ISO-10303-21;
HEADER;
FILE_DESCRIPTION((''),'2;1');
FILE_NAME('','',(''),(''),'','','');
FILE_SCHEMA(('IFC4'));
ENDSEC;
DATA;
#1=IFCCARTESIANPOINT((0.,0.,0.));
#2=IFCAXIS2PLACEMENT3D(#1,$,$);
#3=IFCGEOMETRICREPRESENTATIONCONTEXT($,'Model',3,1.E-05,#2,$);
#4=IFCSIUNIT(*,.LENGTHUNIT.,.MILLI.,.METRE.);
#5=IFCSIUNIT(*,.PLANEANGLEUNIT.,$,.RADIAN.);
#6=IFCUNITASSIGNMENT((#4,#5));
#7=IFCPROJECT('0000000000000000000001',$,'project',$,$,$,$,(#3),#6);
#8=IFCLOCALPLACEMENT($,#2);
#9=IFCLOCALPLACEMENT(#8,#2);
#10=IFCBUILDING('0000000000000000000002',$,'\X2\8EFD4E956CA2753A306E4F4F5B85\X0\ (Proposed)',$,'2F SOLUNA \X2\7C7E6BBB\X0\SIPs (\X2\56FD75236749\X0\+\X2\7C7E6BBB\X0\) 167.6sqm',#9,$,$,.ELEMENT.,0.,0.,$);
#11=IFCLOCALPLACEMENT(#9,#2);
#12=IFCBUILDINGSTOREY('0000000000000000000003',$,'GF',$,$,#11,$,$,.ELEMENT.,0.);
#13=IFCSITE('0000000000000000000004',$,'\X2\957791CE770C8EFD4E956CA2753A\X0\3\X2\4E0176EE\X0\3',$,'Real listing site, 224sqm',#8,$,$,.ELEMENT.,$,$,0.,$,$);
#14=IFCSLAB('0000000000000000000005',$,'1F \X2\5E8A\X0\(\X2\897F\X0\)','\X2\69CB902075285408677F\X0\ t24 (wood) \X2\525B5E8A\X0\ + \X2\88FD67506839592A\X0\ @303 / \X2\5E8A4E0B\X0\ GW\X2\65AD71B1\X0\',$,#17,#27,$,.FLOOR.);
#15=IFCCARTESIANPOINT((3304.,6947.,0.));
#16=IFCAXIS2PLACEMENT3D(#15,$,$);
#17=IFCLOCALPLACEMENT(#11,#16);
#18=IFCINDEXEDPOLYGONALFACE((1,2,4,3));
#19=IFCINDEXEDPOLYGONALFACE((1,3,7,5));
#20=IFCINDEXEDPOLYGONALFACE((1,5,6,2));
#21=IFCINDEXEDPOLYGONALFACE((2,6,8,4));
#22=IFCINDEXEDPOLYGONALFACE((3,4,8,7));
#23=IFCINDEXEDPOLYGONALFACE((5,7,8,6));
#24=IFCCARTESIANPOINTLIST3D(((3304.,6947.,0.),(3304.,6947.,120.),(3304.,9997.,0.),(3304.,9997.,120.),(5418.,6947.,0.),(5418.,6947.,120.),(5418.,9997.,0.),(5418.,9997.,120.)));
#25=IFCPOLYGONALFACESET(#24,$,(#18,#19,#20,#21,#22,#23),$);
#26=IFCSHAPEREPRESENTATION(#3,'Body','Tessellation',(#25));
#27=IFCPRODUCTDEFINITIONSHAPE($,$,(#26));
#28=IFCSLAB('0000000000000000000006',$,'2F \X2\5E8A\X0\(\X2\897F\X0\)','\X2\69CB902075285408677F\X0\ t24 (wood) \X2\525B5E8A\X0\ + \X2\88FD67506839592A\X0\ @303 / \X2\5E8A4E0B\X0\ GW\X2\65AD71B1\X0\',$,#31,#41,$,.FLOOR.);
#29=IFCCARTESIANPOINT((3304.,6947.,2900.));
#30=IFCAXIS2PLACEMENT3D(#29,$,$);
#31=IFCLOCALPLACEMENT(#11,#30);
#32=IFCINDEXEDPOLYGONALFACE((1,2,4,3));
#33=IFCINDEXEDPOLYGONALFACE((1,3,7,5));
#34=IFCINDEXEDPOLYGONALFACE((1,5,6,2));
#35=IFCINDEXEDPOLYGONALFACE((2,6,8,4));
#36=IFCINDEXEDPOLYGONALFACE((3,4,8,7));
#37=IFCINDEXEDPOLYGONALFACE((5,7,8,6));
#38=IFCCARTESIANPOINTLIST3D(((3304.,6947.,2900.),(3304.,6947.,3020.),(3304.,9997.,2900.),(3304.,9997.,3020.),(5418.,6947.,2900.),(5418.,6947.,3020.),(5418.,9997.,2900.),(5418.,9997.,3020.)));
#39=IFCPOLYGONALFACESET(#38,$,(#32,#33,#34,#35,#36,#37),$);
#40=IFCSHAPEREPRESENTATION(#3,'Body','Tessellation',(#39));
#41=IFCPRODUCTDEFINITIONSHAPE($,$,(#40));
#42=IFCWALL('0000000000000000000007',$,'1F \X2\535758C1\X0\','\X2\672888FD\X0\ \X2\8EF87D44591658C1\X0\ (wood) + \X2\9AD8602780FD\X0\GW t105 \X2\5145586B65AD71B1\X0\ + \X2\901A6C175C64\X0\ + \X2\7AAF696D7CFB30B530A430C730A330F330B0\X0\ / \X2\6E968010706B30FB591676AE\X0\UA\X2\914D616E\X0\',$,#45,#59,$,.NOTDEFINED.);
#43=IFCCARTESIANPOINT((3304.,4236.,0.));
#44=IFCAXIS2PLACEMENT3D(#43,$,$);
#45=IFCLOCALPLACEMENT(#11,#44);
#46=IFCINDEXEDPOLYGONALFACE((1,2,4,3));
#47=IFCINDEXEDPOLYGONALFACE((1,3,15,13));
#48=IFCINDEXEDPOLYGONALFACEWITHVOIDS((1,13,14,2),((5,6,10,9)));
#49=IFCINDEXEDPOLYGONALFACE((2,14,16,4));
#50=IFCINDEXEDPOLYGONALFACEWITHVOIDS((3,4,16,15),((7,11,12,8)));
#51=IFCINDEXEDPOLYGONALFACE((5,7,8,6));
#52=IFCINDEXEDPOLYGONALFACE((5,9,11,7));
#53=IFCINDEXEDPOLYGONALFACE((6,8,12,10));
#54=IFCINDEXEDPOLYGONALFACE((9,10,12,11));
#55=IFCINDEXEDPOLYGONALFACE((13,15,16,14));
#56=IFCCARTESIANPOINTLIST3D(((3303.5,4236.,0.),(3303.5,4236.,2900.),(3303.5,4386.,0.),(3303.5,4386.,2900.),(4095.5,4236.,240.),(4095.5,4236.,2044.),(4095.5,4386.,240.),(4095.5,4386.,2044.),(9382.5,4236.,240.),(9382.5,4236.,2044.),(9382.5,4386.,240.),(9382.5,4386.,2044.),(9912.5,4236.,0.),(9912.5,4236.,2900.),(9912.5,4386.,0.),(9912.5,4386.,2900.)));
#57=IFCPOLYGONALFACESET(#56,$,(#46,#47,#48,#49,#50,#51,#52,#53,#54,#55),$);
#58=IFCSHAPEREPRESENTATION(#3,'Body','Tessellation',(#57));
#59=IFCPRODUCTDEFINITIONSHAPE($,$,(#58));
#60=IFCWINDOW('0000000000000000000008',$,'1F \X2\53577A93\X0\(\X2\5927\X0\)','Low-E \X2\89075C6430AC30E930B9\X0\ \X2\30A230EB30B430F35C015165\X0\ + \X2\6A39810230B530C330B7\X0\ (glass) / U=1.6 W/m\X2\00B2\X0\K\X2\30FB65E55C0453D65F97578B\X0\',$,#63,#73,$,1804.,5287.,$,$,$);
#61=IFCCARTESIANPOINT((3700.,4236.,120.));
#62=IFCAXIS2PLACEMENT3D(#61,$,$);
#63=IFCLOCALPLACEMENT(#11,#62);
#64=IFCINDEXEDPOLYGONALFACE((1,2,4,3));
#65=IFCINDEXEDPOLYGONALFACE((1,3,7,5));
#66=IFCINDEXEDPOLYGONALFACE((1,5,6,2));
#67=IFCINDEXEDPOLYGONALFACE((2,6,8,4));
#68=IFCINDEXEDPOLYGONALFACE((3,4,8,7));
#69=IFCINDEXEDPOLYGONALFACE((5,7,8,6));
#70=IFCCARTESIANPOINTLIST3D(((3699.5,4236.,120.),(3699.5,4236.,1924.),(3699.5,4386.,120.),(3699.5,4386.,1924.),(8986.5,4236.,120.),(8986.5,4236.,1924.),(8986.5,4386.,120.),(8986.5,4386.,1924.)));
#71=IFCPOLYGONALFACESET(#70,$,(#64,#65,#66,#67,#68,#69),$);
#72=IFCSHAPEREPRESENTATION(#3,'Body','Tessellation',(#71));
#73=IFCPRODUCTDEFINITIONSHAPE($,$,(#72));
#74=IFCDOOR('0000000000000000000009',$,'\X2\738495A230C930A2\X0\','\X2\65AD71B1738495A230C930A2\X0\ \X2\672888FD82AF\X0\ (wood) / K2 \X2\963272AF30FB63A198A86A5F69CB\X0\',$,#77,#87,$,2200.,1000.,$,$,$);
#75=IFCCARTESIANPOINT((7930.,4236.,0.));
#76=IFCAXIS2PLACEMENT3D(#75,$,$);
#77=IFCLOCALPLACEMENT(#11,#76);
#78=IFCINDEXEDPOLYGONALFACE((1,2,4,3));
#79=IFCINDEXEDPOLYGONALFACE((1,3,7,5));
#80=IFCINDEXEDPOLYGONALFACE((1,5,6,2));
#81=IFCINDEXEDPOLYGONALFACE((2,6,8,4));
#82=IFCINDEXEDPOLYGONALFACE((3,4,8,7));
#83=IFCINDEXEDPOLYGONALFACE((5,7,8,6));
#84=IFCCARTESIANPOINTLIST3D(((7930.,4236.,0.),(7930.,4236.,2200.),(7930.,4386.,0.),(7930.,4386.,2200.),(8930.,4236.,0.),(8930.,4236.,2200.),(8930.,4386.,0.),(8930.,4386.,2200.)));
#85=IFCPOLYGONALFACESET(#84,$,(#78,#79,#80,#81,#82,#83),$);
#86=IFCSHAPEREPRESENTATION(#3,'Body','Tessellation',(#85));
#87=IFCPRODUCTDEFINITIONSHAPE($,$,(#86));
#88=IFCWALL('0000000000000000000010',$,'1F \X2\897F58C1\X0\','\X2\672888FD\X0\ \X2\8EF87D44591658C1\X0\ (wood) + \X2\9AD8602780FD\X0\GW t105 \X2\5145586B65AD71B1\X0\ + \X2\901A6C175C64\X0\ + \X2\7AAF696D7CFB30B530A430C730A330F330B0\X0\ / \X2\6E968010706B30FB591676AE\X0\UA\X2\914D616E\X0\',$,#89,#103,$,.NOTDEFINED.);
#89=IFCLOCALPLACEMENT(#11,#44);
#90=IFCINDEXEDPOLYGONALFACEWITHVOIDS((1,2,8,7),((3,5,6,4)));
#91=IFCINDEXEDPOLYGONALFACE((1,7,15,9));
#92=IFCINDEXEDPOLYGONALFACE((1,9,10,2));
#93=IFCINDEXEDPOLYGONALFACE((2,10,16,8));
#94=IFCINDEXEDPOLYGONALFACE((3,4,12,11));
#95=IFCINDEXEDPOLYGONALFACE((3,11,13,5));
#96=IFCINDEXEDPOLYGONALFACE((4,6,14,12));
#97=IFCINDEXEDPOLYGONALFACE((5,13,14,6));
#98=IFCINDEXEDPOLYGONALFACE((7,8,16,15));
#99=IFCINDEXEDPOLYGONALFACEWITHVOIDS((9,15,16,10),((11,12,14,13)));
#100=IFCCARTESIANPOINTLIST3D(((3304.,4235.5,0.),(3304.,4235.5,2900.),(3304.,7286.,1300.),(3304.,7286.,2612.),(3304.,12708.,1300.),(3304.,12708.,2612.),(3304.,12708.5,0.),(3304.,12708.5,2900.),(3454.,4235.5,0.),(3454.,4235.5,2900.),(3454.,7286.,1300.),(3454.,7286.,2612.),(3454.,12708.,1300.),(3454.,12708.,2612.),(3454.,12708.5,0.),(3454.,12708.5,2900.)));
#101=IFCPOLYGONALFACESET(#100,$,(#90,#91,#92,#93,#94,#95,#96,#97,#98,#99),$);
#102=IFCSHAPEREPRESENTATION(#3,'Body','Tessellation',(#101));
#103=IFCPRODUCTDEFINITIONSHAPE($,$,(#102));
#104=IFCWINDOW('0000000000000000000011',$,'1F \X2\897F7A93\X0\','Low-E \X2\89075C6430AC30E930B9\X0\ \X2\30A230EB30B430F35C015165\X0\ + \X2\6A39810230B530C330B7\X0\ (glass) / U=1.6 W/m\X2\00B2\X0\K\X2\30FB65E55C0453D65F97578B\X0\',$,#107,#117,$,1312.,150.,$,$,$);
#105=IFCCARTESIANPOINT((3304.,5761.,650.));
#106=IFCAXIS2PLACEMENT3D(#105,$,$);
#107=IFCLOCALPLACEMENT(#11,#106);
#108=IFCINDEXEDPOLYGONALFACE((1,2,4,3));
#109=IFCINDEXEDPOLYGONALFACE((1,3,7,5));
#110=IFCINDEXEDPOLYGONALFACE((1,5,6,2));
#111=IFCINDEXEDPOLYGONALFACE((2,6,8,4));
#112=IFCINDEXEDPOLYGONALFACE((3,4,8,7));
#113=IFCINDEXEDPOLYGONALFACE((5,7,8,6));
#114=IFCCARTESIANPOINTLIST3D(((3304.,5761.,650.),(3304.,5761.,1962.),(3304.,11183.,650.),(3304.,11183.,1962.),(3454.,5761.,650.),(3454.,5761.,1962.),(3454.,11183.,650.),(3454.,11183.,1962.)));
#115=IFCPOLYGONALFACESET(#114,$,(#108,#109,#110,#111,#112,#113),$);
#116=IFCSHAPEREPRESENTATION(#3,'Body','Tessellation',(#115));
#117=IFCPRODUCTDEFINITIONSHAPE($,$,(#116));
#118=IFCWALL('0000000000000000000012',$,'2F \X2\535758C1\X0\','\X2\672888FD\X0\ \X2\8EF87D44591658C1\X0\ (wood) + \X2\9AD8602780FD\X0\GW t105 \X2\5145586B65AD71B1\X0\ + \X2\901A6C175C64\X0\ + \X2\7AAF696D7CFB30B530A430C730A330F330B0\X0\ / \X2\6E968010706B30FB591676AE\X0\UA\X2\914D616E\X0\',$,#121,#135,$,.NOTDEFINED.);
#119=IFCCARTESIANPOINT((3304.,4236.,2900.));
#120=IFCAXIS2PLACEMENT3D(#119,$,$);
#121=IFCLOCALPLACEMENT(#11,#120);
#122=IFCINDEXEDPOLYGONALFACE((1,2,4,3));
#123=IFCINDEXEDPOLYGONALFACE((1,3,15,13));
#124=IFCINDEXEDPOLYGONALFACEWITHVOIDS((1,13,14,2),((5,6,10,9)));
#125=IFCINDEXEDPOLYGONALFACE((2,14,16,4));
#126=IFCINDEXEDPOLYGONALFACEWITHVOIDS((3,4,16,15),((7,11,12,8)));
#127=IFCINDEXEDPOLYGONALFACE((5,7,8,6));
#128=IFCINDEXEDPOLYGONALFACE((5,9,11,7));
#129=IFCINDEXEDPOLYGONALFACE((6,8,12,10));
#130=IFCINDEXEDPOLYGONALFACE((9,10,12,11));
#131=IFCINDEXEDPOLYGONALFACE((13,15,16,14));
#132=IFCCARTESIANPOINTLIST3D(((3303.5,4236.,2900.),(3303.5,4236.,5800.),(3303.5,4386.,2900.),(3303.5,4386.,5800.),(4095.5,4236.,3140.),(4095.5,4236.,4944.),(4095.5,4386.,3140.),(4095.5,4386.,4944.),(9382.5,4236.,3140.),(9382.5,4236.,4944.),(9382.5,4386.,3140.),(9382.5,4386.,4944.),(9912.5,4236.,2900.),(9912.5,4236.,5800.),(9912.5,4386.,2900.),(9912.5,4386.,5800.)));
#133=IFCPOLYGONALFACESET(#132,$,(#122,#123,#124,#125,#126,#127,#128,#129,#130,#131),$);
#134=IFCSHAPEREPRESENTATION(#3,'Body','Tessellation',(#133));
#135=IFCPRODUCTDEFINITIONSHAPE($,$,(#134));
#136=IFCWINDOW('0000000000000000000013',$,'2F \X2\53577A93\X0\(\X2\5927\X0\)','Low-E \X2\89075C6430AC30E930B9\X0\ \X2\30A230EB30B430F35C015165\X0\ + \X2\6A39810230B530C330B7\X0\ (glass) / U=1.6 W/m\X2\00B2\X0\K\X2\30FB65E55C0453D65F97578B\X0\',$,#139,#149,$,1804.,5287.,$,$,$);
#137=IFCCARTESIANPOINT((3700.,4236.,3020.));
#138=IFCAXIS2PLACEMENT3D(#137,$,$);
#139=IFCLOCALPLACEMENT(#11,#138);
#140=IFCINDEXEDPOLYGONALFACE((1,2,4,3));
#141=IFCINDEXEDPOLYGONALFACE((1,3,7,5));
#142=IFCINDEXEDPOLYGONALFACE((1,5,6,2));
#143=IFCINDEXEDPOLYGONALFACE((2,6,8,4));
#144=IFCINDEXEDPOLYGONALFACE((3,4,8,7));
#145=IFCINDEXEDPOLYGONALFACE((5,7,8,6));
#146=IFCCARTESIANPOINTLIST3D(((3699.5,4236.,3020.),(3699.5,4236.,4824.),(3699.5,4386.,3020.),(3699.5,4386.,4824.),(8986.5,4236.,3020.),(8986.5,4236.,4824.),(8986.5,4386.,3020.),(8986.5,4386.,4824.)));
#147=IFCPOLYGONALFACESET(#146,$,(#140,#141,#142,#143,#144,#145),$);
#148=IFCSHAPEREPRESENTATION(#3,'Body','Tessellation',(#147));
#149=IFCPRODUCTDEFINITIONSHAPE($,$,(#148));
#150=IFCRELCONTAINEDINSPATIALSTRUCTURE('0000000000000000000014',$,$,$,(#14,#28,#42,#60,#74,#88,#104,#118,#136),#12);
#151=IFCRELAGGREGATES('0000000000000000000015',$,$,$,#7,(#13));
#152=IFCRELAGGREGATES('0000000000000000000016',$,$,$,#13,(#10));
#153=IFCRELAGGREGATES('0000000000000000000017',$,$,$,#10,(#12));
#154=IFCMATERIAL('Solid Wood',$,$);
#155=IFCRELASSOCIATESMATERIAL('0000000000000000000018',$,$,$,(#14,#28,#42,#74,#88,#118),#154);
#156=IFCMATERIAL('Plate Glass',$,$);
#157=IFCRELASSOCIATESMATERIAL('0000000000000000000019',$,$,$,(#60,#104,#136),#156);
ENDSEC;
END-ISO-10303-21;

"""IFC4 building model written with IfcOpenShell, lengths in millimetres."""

from ifc_helpers import new_model, si_unit, frame, frame_2d, origin, place, context, project, spatial, rectangle, extrude, material, element, fill, save


model = new_model("IFC4")

# Units and contexts
model_context = context("Model", 3, precision=1e-05, world=origin())
ifc_project = project(units=[si_unit("LENGTHUNIT", "METRE", prefix="MILLI"), si_unit("PLANEANGLEUNIT", "RADIAN")], contexts=[model_context])

# Site, building, storey
site_placement = place(None, origin())
site = spatial("IfcSite", under=ifc_project, at=site_placement, Name="長野県軽井沢町3丁目3", ObjectType="Real listing site, 224sqm", CompositionType="ELEMENT", RefElevation=0.0)
building_placement = place(site_placement, origin())
building = spatial("IfcBuilding", under=site, at=building_placement, Name="軽井沢町の住宅 (Proposed)", ObjectType="2F SOLUNA 籾殻SIPs (国産杉+籾殻) 167.6sqm", CompositionType="ELEMENT", ElevationOfRefHeight=0.0, ElevationOfTerrain=0.0)
storey_placement = place(building_placement, origin())
storey = spatial("IfcBuildingStorey", under=building, at=storey_placement, Name="GF", CompositionType="ELEMENT", Elevation=0.0)

# Slabs
ifc_material_1 = material(Name="Solid Wood")
slab_1_placement = place(storey_placement, frame((3304.0, 6947.0, 0.0)))
element("IfcSlab", 1, at=slab_1_placement, inside=storey, material=ifc_material_1, Name="1F 床(西)", Description="構造用合板 t24 (wood) 剛床 + 製材根太 @303 / 床下 GW断熱", PredefinedType="FLOOR", context=model_context, shape_type="SweptSolid", body=[
    extrude(rectangle(XDim=2114.0, YDim=3050.0, at=frame_2d((1057.0, 1525.0))), frame((3304.0, 6947.0, 0.0)), (0.0, 0.0, 1.0), 120.0),
])
slab_2_placement = place(storey_placement, frame((3304.0, 6947.0, 2900.0)))
element("IfcSlab", 2, at=slab_2_placement, inside=storey, material=ifc_material_1, Name="2F 床(西)", Description="構造用合板 t24 (wood) 剛床 + 製材根太 @303 / 床下 GW断熱", PredefinedType="FLOOR", context=model_context, shape_type="SweptSolid", body=[
    extrude(rectangle(XDim=2114.0, YDim=3050.0, at=frame_2d((1057.0, 1525.0))), frame((3304.0, 6947.0, 2900.0)), (0.0, 0.0, 1.0), 120.0),
])

# Wall, openings, window, door
wall_1_placement = place(storey_placement, frame((3304.0, 4236.0, 0.0)))
wall_1 = element("IfcWall", 3, at=wall_1_placement, inside=storey, material=ifc_material_1, Name="1F 南壁", Description="木製 軸組外壁 (wood) + 高性能GW t105 充填断熱 + 通気層 + 窯業系サイディング / 準耐火・外皮UA配慮", PredefinedType="NOTDEFINED", context=model_context, shape_type="SweptSolid", body=[
    extrude(rectangle(XDim=6609.0, YDim=150.0, at=frame_2d((3304.0, 75.0))), frame((3304.0, 4236.0, 0.0)), (0.0, 0.0, 1.0), 2900.0),
])
opening_1_placement = place(storey_placement, frame((3700.0, 4236.0, 120.0)))
opening_1 = element("IfcOpeningElement", 4, at=opening_1_placement, cuts=wall_1, PredefinedType="NOTDEFINED", context=model_context, shape_type="SweptSolid", body=[
    extrude(rectangle(XDim=5287.0, YDim=150.0, at=frame_2d((2643.0, 75.0))), frame((3700.0, 4236.0, 120.0)), (0.0, 0.0, 1.0), 1804.0),
])
opening_2_placement = place(storey_placement, frame((7930.0, 4236.0, 0.0)))
opening_2 = element("IfcOpeningElement", 5, at=opening_2_placement, cuts=wall_1, PredefinedType="NOTDEFINED", context=model_context, shape_type="SweptSolid", body=[
    extrude(rectangle(XDim=1000.0, YDim=150.0, at=frame_2d((500.0, 75.0))), frame((7930.0, 4236.0, 0.0)), (0.0, 0.0, 1.0), 2200.0),
])
ifc_material_2 = material(Name="Plate Glass")
window_1_placement = place(storey_placement, frame((3700.0, 4236.0, 120.0)))
window_1 = element("IfcWindow", 6, at=window_1_placement, inside=storey, material=ifc_material_2, Name="1F 南窓(大)", Description="Low-E 複層ガラス アルゴン封入 + 樹脂サッシ (glass) / U=1.6 W/m²K・日射取得型", OverallHeight=1804.0, OverallWidth=5287.0, context=model_context, shape_type="SweptSolid", body=[
    extrude(rectangle(XDim=5287.0, YDim=150.0, at=frame_2d((2643.0, 75.0))), frame((3700.0, 4236.0, 120.0)), (0.0, 0.0, 1.0), 1804.0),
])
fill(opening_1, window_1)
door_placement = place(storey_placement, frame((7930.0, 4236.0, 0.0)))
door = element("IfcDoor", 7, at=door_placement, inside=storey, material=ifc_material_1, Name="玄関ドア", Description="断熱玄関ドア 木製芯 (wood) / K2 防犯・採風機構", OverallHeight=2200.0, OverallWidth=1000.0, context=model_context, shape_type="SweptSolid", body=[
    extrude(rectangle(XDim=1000.0, YDim=150.0, at=frame_2d((500.0, 75.0))), frame((7930.0, 4236.0, 0.0)), (0.0, 0.0, 1.0), 2200.0),
])
fill(opening_2, door)

# Walls, openings, windows
wall_2_placement = place(storey_placement, frame((3304.0, 4236.0, 0.0)))
wall_2 = element("IfcWall", 8, at=wall_2_placement, inside=storey, material=ifc_material_1, Name="1F 西壁", Description="木製 軸組外壁 (wood) + 高性能GW t105 充填断熱 + 通気層 + 窯業系サイディング / 準耐火・外皮UA配慮", PredefinedType="NOTDEFINED", context=model_context, shape_type="SweptSolid", body=[
    extrude(rectangle(XDim=150.0, YDim=8473.0, at=frame_2d((75.0, 4236.0))), frame((3304.0, 4236.0, 0.0)), (0.0, 0.0, 1.0), 2900.0),
])
opening_3_placement = place(storey_placement, frame((3304.0, 5761.0, 650.0)))
opening_3 = element("IfcOpeningElement", 9, at=opening_3_placement, cuts=wall_2, PredefinedType="NOTDEFINED", context=model_context, shape_type="SweptSolid", body=[
    extrude(rectangle(XDim=150.0, YDim=5422.0, at=frame_2d((75.0, 2711.0))), frame((3304.0, 5761.0, 650.0)), (0.0, 0.0, 1.0), 1312.0),
])
window_2_placement = place(storey_placement, frame((3304.0, 5761.0, 650.0)))
window_2 = element("IfcWindow", 10, at=window_2_placement, inside=storey, material=ifc_material_2, Name="1F 西窓", Description="Low-E 複層ガラス アルゴン封入 + 樹脂サッシ (glass) / U=1.6 W/m²K・日射取得型", OverallHeight=1312.0, OverallWidth=150.0, context=model_context, shape_type="SweptSolid", body=[
    extrude(rectangle(XDim=150.0, YDim=5422.0, at=frame_2d((75.0, 2711.0))), frame((3304.0, 5761.0, 650.0)), (0.0, 0.0, 1.0), 1312.0),
])
fill(opening_3, window_2)
wall_3_placement = place(storey_placement, frame((3304.0, 4236.0, 2900.0)))
wall_3 = element("IfcWall", 11, at=wall_3_placement, inside=storey, material=ifc_material_1, Name="2F 南壁", Description="木製 軸組外壁 (wood) + 高性能GW t105 充填断熱 + 通気層 + 窯業系サイディング / 準耐火・外皮UA配慮", PredefinedType="NOTDEFINED", context=model_context, shape_type="SweptSolid", body=[
    extrude(rectangle(XDim=6609.0, YDim=150.0, at=frame_2d((3304.0, 75.0))), frame((3304.0, 4236.0, 2900.0)), (0.0, 0.0, 1.0), 2900.0),
])
opening_4_placement = place(storey_placement, frame((3700.0, 4236.0, 3020.0)))
opening_4 = element("IfcOpeningElement", 12, at=opening_4_placement, cuts=wall_3, PredefinedType="NOTDEFINED", context=model_context, shape_type="SweptSolid", body=[
    extrude(rectangle(XDim=5287.0, YDim=150.0, at=frame_2d((2643.0, 75.0))), frame((3700.0, 4236.0, 3020.0)), (0.0, 0.0, 1.0), 1804.0),
])
window_3_placement = place(storey_placement, frame((3700.0, 4236.0, 3020.0)))
window_3 = element("IfcWindow", 13, at=window_3_placement, inside=storey, material=ifc_material_2, Name="2F 南窓(大)", Description="Low-E 複層ガラス アルゴン封入 + 樹脂サッシ (glass) / U=1.6 W/m²K・日射取得型", OverallHeight=1804.0, OverallWidth=5287.0, context=model_context, shape_type="SweptSolid", body=[
    extrude(rectangle(XDim=5287.0, YDim=150.0, at=frame_2d((2643.0, 75.0))), frame((3700.0, 4236.0, 3020.0)), (0.0, 0.0, 1.0), 1804.0),
])
fill(opening_4, window_3)

save(model, "model.ifc")
